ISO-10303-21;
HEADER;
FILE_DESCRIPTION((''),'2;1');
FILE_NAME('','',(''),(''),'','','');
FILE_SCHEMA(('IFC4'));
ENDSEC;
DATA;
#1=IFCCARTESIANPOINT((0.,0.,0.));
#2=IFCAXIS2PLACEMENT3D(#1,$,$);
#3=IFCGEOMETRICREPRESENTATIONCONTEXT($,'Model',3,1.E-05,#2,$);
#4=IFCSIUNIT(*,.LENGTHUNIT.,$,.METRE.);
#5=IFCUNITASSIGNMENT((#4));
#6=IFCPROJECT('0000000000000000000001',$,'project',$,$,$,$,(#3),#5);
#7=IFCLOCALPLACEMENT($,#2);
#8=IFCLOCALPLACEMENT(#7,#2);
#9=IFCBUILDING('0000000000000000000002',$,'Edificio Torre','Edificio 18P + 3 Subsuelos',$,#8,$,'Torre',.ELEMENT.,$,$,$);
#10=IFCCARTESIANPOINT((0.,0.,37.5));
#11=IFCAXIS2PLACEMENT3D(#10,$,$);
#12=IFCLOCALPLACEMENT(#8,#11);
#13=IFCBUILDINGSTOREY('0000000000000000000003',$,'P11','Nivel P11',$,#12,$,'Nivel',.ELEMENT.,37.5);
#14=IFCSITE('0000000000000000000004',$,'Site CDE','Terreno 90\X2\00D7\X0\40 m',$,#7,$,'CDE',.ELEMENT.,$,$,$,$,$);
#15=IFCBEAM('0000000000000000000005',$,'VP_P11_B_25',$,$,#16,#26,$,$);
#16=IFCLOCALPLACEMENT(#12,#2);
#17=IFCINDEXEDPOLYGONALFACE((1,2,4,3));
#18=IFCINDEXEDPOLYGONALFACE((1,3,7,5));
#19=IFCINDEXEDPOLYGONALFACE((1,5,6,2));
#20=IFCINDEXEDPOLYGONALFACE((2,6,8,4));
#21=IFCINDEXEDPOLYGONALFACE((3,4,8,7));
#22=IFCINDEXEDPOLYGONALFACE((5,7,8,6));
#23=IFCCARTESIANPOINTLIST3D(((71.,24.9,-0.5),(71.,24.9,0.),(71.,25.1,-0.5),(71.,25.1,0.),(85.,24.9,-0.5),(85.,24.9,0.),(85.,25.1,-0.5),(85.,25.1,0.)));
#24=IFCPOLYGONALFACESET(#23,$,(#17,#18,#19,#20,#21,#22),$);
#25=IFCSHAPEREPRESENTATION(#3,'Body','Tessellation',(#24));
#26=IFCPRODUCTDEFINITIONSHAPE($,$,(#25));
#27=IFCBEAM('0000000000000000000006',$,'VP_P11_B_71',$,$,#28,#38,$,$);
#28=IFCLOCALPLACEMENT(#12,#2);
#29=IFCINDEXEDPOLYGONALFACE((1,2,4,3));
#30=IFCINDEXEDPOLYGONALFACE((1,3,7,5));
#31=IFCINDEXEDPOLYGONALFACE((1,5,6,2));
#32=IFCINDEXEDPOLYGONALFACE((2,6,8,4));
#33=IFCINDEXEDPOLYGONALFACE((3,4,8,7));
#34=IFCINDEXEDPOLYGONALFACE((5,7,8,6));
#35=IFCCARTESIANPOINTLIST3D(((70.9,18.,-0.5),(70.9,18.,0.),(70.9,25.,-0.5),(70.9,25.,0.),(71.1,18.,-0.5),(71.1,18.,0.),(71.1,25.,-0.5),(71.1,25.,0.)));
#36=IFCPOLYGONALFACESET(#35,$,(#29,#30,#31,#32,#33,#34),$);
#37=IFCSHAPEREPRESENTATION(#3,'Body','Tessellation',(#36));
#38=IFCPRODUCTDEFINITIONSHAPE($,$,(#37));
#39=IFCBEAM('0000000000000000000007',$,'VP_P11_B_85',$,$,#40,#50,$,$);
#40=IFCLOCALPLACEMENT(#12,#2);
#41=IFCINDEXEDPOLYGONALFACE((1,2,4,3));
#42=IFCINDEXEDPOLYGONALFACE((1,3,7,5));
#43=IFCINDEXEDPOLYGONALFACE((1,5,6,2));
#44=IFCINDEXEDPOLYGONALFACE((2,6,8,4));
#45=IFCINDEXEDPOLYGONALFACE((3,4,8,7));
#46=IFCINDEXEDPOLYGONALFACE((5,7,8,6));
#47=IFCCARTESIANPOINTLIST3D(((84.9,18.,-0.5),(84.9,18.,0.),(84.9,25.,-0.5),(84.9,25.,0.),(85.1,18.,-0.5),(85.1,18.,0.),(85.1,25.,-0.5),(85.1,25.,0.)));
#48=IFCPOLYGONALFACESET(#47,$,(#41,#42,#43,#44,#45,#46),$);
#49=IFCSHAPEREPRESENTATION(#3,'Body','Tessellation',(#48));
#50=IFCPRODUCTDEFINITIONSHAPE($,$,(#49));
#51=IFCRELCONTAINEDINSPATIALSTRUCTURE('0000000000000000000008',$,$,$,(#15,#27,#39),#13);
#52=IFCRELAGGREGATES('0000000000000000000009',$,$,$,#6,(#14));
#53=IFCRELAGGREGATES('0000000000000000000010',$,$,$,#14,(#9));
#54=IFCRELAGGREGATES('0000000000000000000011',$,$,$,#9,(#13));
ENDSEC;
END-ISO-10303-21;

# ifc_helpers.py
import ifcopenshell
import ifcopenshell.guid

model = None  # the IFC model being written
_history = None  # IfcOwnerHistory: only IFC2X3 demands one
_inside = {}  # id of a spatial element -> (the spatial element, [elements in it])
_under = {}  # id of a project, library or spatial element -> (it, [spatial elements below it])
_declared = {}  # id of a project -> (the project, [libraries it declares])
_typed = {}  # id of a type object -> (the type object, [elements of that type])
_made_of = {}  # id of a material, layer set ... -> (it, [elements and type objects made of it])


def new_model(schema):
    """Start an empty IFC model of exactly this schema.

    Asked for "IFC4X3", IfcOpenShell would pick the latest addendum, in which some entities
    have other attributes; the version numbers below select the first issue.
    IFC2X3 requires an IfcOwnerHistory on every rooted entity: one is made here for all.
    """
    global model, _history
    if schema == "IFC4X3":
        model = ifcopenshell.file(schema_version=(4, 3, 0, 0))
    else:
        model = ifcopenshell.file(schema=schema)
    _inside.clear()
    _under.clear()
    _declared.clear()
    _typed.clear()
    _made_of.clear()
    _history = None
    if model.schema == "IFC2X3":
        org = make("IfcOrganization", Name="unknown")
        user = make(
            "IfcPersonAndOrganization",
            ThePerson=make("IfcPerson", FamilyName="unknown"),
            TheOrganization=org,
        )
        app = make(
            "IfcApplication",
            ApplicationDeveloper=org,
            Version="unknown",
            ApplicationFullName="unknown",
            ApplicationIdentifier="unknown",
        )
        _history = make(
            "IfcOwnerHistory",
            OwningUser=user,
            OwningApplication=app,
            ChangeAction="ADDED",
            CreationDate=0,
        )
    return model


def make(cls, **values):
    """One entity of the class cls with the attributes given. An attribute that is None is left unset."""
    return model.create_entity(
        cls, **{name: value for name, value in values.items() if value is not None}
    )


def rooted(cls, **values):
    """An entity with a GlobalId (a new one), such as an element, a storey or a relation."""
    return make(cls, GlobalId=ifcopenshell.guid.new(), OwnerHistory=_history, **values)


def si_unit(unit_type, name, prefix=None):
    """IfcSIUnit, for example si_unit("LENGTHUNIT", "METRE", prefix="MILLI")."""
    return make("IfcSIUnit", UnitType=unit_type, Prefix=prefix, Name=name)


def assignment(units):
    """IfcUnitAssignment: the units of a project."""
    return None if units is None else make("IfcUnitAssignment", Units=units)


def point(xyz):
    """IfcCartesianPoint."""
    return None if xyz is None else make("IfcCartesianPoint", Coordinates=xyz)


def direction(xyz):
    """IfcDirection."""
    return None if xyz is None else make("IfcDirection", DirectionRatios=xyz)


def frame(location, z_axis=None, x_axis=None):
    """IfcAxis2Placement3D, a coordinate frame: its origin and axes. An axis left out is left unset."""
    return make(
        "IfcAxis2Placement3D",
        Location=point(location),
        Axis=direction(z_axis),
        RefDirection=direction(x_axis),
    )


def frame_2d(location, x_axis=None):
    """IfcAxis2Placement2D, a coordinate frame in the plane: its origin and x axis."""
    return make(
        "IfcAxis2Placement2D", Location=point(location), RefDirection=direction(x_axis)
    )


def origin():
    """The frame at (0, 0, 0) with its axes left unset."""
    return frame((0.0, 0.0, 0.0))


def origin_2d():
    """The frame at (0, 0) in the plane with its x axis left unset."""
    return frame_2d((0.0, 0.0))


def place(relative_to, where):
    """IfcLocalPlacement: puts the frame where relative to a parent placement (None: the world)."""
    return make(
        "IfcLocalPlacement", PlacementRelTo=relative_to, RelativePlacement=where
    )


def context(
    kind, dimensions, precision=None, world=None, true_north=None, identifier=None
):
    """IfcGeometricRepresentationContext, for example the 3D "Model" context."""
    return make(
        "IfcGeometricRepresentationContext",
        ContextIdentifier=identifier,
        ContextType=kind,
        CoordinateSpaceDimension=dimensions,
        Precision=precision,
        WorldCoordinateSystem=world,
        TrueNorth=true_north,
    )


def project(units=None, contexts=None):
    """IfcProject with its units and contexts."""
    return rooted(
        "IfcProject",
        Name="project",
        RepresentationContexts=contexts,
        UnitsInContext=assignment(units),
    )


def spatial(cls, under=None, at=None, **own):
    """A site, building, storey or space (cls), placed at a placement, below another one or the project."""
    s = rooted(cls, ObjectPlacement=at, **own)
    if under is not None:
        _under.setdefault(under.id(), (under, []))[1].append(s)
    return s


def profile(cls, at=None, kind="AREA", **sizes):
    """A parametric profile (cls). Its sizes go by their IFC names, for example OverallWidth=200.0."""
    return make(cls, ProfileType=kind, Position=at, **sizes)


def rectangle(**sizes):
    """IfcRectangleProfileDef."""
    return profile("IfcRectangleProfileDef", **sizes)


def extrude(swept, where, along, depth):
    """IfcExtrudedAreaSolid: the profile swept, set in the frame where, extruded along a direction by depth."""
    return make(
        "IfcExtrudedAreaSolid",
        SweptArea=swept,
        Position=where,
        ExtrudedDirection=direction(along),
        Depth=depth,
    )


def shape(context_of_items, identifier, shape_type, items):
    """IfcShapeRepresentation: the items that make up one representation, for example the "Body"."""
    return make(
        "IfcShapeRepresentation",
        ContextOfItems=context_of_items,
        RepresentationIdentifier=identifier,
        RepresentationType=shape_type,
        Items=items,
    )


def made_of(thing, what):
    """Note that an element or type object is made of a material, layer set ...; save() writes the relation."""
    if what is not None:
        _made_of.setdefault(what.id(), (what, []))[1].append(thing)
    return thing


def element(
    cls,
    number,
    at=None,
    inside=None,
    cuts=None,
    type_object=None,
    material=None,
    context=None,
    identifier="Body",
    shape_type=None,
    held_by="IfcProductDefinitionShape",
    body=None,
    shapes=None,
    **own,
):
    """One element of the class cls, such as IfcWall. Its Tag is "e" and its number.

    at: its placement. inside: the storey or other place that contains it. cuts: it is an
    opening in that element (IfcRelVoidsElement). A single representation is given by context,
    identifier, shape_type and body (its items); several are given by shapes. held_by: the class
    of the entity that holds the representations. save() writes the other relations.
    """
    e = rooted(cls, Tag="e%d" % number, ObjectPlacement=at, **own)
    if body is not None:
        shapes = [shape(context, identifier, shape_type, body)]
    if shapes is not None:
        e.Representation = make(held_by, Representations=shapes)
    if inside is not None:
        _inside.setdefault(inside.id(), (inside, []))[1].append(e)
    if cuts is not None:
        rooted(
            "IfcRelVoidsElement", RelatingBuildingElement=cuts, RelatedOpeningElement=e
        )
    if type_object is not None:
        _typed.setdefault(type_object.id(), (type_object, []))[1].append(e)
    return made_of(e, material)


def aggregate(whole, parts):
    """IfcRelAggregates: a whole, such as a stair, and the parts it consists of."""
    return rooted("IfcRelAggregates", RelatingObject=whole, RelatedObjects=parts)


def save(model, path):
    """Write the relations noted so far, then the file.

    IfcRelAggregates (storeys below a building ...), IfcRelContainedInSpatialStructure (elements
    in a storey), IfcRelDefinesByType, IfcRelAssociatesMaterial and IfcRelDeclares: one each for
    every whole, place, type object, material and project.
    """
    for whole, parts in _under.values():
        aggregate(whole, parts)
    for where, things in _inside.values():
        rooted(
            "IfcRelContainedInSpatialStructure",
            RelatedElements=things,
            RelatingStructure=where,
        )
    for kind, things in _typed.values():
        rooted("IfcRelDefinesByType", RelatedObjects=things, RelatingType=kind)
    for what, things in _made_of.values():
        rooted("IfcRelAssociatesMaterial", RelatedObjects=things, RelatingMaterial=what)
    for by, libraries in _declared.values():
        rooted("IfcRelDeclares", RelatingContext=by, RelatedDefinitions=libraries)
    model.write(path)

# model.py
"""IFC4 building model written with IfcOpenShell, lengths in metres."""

from ifc_helpers import new_model, si_unit, frame, origin, origin_2d, place, context, project, spatial, rectangle, extrude, element, save


model = new_model("IFC4")

# Units and contexts
model_context = context("Model", 3, precision=1e-05, world=origin())
ifc_project = project(units=[si_unit("LENGTHUNIT", "METRE")], contexts=[model_context])

# Site, building, storey
site_placement = place(None, origin())
site = spatial("IfcSite", under=ifc_project, at=site_placement, Name="Site CDE", Description="Terreno 90×40 m", LongName="CDE", CompositionType="ELEMENT")
building_placement = place(site_placement, origin())
building = spatial("IfcBuilding", under=site, at=building_placement, Name="Edificio Torre", Description="Edificio 18P + 3 Subsuelos", LongName="Torre", CompositionType="ELEMENT")
storey_placement = place(building_placement, frame((0.0, 0.0, 37.5)))
storey = spatial("IfcBuildingStorey", under=building, at=storey_placement, Name="P11", Description="Nivel P11", LongName="Nivel", CompositionType="ELEMENT", Elevation=37.5)

# Beams
for number, where, name in (
    (1, (78.0, 25.0, -0.5), "VP_P11_B_25"),
):
    element("IfcBeam", number, at=place(storey_placement, frame(where)), inside=storey, Name=name, context=model_context, shape_type="SweptSolid", body=[
        extrude(rectangle(XDim=14.0, YDim=0.2, at=origin_2d()), origin(), (0.0, 0.0, 1.0), 0.5),
    ])
for number, where, name in (
    (2, (71.0, 21.5, -0.5), "VP_P11_B_71"),
    (3, (85.0, 21.5, -0.5), "VP_P11_B_85"),
):
    element("IfcBeam", number, at=place(storey_placement, frame(where)), inside=storey, Name=name, context=model_context, shape_type="SweptSolid", body=[
        extrude(rectangle(XDim=0.2, YDim=7.0, at=origin_2d()), origin(), (0.0, 0.0, 1.0), 0.5),
    ])

save(model, "model.ifc")
